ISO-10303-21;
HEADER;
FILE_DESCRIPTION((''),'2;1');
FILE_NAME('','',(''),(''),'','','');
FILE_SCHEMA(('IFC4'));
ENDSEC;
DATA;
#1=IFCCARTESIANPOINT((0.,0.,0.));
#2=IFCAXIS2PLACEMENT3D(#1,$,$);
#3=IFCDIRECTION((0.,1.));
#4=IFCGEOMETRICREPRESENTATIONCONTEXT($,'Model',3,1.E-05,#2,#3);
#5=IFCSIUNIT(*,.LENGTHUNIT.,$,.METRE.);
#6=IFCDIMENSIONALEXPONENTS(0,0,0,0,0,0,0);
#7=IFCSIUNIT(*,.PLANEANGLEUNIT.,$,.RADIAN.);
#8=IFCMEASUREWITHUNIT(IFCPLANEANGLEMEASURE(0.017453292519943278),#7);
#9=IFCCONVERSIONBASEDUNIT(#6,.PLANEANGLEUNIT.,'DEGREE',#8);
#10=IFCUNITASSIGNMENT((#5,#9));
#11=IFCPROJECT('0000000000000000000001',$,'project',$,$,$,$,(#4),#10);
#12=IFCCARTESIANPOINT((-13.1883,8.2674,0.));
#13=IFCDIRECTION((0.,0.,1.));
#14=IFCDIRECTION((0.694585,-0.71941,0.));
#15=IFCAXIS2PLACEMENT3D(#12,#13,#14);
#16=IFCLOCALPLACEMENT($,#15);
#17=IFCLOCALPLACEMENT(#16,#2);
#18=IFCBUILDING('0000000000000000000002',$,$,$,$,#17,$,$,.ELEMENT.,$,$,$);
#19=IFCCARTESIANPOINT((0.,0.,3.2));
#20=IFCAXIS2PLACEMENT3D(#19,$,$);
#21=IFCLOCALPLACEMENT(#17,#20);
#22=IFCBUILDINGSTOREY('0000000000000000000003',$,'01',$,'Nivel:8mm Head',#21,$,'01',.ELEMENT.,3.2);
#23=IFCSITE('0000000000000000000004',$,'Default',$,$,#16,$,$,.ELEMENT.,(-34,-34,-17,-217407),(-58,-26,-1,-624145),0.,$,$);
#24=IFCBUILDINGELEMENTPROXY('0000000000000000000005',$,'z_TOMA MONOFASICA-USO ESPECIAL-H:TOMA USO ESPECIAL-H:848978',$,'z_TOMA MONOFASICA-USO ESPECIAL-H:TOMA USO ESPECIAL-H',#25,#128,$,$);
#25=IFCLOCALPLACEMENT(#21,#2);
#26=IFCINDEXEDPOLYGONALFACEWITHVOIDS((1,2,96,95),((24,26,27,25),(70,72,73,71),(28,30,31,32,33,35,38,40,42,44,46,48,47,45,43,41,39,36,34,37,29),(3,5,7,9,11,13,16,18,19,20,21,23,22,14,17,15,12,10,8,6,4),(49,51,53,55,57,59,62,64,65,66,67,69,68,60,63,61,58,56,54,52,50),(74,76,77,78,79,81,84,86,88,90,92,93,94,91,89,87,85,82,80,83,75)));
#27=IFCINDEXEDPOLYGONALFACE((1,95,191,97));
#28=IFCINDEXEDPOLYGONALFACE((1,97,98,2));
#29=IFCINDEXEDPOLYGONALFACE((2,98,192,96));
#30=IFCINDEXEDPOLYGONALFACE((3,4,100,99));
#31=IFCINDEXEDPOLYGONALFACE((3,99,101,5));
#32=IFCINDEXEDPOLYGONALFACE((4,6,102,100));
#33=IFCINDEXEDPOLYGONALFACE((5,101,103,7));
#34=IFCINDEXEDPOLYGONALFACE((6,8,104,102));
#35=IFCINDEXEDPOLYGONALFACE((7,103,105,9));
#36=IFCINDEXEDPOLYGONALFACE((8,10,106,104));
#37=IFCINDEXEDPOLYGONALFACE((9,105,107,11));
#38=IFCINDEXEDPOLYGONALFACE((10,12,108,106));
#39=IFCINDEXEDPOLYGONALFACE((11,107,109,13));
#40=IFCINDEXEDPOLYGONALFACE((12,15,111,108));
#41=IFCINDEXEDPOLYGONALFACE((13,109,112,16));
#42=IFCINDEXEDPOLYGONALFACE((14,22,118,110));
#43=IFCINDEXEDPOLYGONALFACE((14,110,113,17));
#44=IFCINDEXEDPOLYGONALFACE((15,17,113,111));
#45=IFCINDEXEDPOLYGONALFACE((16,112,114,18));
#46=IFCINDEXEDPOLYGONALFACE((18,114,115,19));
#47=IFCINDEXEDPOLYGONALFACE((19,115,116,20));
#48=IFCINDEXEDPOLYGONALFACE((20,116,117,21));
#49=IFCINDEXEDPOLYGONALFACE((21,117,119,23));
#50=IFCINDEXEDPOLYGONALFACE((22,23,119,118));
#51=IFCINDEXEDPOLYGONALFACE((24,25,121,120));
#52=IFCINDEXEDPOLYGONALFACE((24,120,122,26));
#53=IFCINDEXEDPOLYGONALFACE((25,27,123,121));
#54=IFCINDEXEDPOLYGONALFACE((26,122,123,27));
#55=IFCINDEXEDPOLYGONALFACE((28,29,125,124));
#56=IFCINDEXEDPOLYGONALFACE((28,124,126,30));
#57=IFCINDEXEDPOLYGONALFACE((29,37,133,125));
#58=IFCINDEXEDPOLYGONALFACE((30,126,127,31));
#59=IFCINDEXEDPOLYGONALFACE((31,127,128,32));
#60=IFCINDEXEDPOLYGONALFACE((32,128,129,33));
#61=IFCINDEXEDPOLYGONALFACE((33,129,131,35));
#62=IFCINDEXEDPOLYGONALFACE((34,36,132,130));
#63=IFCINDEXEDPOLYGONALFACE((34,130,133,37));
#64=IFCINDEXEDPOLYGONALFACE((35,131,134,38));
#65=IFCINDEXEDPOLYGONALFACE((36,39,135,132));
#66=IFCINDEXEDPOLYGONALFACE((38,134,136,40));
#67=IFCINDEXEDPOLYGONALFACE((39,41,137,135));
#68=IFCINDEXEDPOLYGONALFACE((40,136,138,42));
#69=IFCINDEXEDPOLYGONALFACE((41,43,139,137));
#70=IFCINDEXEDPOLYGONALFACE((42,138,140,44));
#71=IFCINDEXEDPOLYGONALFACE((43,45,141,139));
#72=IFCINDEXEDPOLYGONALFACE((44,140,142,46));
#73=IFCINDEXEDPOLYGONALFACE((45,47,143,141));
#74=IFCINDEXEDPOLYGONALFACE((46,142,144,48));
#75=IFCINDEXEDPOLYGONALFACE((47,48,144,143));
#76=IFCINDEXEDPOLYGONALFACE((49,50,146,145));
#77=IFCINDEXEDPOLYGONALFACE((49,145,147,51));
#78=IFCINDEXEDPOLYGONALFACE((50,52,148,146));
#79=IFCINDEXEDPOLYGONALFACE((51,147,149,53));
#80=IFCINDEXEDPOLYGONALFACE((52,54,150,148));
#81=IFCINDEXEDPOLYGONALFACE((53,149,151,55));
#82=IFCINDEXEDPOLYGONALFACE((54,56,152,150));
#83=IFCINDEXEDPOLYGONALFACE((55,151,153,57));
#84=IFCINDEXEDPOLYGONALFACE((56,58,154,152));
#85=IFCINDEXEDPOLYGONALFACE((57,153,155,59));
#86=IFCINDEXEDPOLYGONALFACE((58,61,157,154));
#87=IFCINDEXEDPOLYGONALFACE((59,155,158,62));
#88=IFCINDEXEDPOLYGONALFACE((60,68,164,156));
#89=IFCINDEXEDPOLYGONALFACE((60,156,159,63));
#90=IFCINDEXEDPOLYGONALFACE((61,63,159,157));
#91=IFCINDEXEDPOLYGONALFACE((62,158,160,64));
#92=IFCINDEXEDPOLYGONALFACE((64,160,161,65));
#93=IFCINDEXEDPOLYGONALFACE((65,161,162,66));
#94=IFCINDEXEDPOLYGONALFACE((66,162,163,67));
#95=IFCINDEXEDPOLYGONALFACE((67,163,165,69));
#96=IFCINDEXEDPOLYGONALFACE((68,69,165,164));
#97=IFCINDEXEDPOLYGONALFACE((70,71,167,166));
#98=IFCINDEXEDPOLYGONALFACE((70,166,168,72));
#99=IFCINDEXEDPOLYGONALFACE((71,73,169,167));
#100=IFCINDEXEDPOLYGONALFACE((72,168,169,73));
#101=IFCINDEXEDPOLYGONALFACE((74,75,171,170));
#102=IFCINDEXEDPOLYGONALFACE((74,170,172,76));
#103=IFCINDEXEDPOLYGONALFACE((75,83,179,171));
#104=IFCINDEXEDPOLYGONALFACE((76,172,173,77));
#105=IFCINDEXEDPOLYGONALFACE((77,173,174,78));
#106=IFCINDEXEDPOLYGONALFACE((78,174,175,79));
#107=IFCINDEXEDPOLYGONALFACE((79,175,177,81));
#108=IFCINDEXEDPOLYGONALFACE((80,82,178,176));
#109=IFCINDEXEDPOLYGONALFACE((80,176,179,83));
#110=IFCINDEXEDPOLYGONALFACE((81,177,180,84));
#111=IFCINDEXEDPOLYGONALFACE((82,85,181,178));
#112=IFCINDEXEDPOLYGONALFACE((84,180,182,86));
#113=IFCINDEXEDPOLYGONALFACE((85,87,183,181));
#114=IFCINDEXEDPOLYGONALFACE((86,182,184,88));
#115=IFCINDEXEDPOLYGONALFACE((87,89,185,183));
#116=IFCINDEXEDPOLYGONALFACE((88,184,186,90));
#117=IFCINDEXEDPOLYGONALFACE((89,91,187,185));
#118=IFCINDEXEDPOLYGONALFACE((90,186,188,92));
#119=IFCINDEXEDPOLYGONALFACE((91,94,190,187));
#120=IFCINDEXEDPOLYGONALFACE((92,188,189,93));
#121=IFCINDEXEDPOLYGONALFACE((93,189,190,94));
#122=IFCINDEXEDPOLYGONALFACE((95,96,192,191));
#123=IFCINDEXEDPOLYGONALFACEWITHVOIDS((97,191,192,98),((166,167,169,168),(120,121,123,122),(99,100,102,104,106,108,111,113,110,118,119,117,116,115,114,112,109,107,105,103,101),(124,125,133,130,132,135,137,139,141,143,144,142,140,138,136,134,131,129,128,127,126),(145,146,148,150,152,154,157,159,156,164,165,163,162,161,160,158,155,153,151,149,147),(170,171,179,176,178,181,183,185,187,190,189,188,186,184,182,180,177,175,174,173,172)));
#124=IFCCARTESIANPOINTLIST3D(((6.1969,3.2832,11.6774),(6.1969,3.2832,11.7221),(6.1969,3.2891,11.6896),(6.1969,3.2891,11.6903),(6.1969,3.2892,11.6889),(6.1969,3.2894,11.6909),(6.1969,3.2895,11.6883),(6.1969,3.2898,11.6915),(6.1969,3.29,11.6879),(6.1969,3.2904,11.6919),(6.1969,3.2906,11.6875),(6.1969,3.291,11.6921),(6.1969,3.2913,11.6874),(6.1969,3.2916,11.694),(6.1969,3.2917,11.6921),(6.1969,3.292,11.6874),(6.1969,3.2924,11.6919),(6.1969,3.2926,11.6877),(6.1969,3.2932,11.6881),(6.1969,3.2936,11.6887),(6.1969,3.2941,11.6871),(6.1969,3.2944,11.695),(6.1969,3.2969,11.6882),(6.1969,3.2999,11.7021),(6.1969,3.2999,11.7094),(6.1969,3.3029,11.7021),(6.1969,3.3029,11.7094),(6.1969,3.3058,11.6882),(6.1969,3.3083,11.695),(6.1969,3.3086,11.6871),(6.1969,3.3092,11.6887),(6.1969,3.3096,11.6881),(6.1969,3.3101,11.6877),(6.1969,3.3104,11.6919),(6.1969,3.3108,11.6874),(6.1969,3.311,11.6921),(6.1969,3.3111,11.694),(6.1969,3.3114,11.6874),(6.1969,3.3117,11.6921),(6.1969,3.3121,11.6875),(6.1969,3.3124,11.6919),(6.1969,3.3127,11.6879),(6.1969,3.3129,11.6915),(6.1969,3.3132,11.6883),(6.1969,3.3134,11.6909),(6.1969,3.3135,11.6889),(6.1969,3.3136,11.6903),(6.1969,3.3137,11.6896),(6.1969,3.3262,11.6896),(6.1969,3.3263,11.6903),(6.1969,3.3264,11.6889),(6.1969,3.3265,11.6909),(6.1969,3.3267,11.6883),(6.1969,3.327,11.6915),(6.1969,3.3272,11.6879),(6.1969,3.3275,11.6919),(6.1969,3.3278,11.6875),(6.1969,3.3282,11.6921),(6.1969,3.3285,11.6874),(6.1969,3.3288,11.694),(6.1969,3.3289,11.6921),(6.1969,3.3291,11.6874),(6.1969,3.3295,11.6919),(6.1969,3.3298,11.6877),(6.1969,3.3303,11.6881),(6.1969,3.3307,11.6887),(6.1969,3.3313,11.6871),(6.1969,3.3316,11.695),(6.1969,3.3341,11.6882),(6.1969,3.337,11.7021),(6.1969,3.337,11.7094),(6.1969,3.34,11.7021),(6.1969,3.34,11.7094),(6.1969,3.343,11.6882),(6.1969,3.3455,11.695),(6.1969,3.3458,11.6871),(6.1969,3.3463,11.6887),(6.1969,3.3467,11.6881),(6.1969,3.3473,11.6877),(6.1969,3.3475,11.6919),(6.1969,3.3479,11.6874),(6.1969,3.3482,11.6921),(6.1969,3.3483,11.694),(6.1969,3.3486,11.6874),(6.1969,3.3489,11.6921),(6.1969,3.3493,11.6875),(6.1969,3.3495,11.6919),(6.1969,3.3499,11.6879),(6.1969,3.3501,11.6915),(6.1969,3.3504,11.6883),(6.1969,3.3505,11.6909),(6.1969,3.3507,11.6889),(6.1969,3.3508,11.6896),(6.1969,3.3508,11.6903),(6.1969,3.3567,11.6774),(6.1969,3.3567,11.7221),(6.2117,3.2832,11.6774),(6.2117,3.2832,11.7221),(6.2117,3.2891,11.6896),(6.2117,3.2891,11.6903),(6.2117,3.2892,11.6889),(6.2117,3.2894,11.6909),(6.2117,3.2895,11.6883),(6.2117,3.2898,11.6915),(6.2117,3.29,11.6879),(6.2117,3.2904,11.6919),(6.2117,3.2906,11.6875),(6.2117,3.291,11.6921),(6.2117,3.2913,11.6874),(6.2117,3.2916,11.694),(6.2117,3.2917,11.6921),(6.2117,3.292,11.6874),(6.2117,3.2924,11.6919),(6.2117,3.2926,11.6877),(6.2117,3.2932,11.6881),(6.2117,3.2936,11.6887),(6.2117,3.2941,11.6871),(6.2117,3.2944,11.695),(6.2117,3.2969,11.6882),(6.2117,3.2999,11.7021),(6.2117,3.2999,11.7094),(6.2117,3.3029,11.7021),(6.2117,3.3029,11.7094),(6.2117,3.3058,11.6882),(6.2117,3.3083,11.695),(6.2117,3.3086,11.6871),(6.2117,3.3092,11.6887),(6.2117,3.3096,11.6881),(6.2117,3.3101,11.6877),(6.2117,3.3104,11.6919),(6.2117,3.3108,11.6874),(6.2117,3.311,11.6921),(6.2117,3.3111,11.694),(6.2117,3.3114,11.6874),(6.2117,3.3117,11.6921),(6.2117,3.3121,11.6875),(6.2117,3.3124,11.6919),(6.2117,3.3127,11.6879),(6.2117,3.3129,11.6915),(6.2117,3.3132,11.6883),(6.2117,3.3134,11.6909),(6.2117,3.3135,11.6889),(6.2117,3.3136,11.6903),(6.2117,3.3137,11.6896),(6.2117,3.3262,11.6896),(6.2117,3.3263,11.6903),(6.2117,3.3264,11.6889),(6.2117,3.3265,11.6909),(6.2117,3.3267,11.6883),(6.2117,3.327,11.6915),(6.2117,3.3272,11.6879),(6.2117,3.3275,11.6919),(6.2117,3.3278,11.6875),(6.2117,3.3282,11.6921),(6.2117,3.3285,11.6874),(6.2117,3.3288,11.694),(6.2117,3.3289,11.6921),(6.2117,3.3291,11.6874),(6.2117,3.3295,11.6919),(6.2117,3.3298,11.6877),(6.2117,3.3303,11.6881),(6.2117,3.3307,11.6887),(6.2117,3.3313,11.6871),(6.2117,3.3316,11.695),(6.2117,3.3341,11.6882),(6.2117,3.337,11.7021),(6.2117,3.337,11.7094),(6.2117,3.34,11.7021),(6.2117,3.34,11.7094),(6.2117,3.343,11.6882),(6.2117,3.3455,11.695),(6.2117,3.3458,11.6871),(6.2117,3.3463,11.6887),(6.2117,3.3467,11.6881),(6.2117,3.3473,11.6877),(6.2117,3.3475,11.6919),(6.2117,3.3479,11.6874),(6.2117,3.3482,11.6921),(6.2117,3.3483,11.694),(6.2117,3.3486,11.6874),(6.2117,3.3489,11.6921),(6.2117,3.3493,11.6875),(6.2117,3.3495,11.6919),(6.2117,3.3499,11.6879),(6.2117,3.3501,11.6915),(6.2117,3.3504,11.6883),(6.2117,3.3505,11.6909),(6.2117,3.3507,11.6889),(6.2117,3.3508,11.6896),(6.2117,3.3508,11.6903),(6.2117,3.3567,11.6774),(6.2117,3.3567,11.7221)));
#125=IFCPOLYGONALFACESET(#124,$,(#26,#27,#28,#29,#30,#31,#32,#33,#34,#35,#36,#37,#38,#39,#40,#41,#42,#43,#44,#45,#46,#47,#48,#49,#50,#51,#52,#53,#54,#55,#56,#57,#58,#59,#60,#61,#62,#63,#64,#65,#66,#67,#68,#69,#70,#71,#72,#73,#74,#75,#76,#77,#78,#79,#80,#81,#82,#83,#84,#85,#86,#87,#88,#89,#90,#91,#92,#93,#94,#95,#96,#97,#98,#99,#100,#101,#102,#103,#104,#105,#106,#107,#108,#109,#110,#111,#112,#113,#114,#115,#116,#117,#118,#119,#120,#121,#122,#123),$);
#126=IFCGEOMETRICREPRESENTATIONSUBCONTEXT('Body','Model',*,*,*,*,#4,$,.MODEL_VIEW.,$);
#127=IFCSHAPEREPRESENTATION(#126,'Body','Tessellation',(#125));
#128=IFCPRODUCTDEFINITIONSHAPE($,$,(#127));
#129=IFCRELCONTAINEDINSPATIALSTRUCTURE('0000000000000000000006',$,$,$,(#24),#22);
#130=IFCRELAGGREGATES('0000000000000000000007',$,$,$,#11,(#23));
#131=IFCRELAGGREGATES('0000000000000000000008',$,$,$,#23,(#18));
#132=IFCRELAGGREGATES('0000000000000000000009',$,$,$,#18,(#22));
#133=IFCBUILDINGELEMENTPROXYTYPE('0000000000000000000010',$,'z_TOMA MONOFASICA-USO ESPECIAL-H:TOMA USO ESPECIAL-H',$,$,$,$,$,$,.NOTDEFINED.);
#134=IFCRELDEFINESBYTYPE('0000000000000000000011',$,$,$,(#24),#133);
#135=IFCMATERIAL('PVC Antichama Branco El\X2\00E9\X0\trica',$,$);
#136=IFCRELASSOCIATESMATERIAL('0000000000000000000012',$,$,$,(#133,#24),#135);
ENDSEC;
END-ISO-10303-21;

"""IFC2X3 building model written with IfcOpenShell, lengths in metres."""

from ifc_helpers import new_model, entity, si_unit, converted_unit, direction, frame, frame_2d, origin, place, context, subcontext, project, spatial, polyline, circle_curve, parameter, trimmed, segment, composite_curve, outline, extrude, source, transform, mapped, material, type_object, type_shapes, element, save


model = new_model("IFC2X3")

# Units and contexts
model_context = context("Model", 3, precision=1e-05, world=origin(), true_north=direction((0.0, 1.0)))
body_context = subcontext(model_context, "Body", "Model", "MODEL_VIEW")
ifc_project = project(units=[si_unit("LENGTHUNIT", "METRE"), converted_unit("PLANEANGLEUNIT", "DEGREE", entity("IfcPlaneAngleMeasure", 0.017453292519943278), si_unit("PLANEANGLEUNIT", "RADIAN"), dimensions=[0, 0, 0, 0, 0, 0, 0])], contexts=[model_context])

# Site, building, storey
site_placement = place(None, frame((-13.1883, 8.2674, 0.0), z_axis=(0.0, 0.0, 1.0), x_axis=(0.694585, -0.71941, 0.0)))
site = spatial("IfcSite", under=ifc_project, at=site_placement, Name="Default", CompositionType="ELEMENT", RefLatitude=(-34, -34, -17, -217407), RefLongitude=(-58, -26, -1, -624145), RefElevation=0.0)
building_placement = place(site_placement, origin())
building = spatial("IfcBuilding", under=site, at=building_placement, CompositionType="ELEMENT")
storey_placement = place(building_placement, frame((0.0, 0.0, 3.2)))
storey = spatial("IfcBuildingStorey", under=building, at=storey_placement, Name="01", ObjectType="Nivel:8mm Head", LongName="01", CompositionType="ELEMENT", Elevation=3.2)

# Building element proxy
ifc_material_1 = material(Name="PVC Antichama Branco Elétrica")
building_element_proxy_type_1 = type_object("IfcBuildingElementProxyType", Name="z_TOMA MONOFASICA-USO ESPECIAL-H:TOMA USO ESPECIAL-H", PredefinedType="NOTDEFINED", material=ifc_material_1)
shared_shape_1 = source(origin(), body_context, "Body", "SweptSolid", [
    extrude(outline(polyline([(-0.0368, -0.0223), (0.0368, -0.0223), (0.0368, 0.0223), (-0.0368, 0.0223), (-0.0368, -0.0223)]), holes=[composite_curve([segment(polyline([(0.0141, 0.0115), (0.0116, 0.0047)]), True, "CONTINUOUS"), segment(polyline([(0.0116, 0.0047), (0.0088, 0.0057)]), True, "CONTINUOUS"), segment(polyline([(0.0088, 0.0057), (0.0096, 0.0078)]), True, "CONTINUOUS"), segment(trimmed(circle_curve(frame_2d((0.0087, 0.0099), x_axis=(1.0, 0.0)), 0.0024), [parameter(27.118901)], [parameter(292.881099)], True, "PARAMETER"), False, "CONTINUOUS"), segment(polyline([(0.0108, 0.011), (0.0113, 0.0126)]), True, "CONTINUOUS"), segment(polyline([(0.0113, 0.0126), (0.0141, 0.0115)]), True, "CONTINUOUS")], self_intersect=False), composite_curve([segment(polyline([(0.0255, 0.0047), (0.023, 0.0115)]), True, "CONTINUOUS"), segment(polyline([(0.023, 0.0115), (0.0258, 0.0126)]), True, "CONTINUOUS"), segment(polyline([(0.0258, 0.0126), (0.0264, 0.011)]), True, "CONTINUOUS"), segment(trimmed(circle_curve(frame_2d((0.0285, 0.0099), x_axis=(1.0, 0.0)), 0.0024), [parameter(247.118901)], [parameter(152.881099)], True, "PARAMETER"), False, "CONTINUOUS"), segment(polyline([(0.0276, 0.0078), (0.0283, 0.0057)]), True, "CONTINUOUS"), segment(polyline([(0.0283, 0.0057), (0.0255, 0.0047)]), True, "CONTINUOUS")], self_intersect=False), polyline([(0.0201, -0.0024), (0.0201, -0.0097), (0.0171, -0.0097), (0.0171, -0.0024), (0.0201, -0.0024)]), composite_curve([segment(polyline([(-0.0141, 0.0115), (-0.0113, 0.0126)]), True, "CONTINUOUS"), segment(polyline([(-0.0113, 0.0126), (-0.0108, 0.011)]), True, "CONTINUOUS"), segment(trimmed(circle_curve(frame_2d((-0.0087, 0.0099), x_axis=(1.0, 0.0)), 0.0024), [parameter(247.118901)], [parameter(152.881099)], True, "PARAMETER"), False, "CONTINUOUS"), segment(polyline([(-0.0096, 0.0078), (-0.0088, 0.0057)]), True, "CONTINUOUS"), segment(polyline([(-0.0088, 0.0057), (-0.0116, 0.0047)]), True, "CONTINUOUS"), segment(polyline([(-0.0116, 0.0047), (-0.0141, 0.0115)]), True, "CONTINUOUS")], self_intersect=False), composite_curve([segment(polyline([(-0.0255, 0.0047), (-0.0283, 0.0057)]), True, "CONTINUOUS"), segment(polyline([(-0.0283, 0.0057), (-0.0276, 0.0078)]), True, "CONTINUOUS"), segment(trimmed(circle_curve(frame_2d((-0.0285, 0.0099), x_axis=(1.0, 0.0)), 0.0024), [parameter(27.118901)], [parameter(292.881099)], True, "PARAMETER"), False, "CONTINUOUS"), segment(polyline([(-0.0264, 0.011), (-0.0258, 0.0126)]), True, "CONTINUOUS"), segment(polyline([(-0.0258, 0.0126), (-0.023, 0.0115)]), True, "CONTINUOUS"), segment(polyline([(-0.023, 0.0115), (-0.0255, 0.0047)]), True, "CONTINUOUS")], self_intersect=False), polyline([(-0.0201, -0.0024), (-0.0171, -0.0024), (-0.0171, -0.0097), (-0.0201, -0.0097), (-0.0201, -0.0024)])]), frame((0.0, -0.005, 0.0223), z_axis=(0.0, 1.0, 0.0), x_axis=(1.0, 0.0, 0.0)), (0.0, 0.0, 1.0), 0.0148),
])
type_shapes(building_element_proxy_type_1, [shared_shape_1])
for number, where, z_axis, x_axis, name in (
    (1, (6.2019, 3.3199, 11.6774), (0.0, 0.0, 1.0), (0.0, -1.0, 0.0), "z_TOMA MONOFASICA-USO ESPECIAL-H:TOMA USO ESPECIAL-H:848978"),
):
    element("IfcBuildingElementProxy", number, at=place(storey_placement, frame(where, z_axis=z_axis, x_axis=x_axis)), inside=storey, type_object=building_element_proxy_type_1, material=ifc_material_1, Name=name, ObjectType="z_TOMA MONOFASICA-USO ESPECIAL-H:TOMA USO ESPECIAL-H", context=body_context, shape_type="MappedRepresentation", body=[
        mapped(shared_shape_1, transform((0.0, 0.0, 0.0), scale=1.0)),
    ])

save(model, "model.ifc")
